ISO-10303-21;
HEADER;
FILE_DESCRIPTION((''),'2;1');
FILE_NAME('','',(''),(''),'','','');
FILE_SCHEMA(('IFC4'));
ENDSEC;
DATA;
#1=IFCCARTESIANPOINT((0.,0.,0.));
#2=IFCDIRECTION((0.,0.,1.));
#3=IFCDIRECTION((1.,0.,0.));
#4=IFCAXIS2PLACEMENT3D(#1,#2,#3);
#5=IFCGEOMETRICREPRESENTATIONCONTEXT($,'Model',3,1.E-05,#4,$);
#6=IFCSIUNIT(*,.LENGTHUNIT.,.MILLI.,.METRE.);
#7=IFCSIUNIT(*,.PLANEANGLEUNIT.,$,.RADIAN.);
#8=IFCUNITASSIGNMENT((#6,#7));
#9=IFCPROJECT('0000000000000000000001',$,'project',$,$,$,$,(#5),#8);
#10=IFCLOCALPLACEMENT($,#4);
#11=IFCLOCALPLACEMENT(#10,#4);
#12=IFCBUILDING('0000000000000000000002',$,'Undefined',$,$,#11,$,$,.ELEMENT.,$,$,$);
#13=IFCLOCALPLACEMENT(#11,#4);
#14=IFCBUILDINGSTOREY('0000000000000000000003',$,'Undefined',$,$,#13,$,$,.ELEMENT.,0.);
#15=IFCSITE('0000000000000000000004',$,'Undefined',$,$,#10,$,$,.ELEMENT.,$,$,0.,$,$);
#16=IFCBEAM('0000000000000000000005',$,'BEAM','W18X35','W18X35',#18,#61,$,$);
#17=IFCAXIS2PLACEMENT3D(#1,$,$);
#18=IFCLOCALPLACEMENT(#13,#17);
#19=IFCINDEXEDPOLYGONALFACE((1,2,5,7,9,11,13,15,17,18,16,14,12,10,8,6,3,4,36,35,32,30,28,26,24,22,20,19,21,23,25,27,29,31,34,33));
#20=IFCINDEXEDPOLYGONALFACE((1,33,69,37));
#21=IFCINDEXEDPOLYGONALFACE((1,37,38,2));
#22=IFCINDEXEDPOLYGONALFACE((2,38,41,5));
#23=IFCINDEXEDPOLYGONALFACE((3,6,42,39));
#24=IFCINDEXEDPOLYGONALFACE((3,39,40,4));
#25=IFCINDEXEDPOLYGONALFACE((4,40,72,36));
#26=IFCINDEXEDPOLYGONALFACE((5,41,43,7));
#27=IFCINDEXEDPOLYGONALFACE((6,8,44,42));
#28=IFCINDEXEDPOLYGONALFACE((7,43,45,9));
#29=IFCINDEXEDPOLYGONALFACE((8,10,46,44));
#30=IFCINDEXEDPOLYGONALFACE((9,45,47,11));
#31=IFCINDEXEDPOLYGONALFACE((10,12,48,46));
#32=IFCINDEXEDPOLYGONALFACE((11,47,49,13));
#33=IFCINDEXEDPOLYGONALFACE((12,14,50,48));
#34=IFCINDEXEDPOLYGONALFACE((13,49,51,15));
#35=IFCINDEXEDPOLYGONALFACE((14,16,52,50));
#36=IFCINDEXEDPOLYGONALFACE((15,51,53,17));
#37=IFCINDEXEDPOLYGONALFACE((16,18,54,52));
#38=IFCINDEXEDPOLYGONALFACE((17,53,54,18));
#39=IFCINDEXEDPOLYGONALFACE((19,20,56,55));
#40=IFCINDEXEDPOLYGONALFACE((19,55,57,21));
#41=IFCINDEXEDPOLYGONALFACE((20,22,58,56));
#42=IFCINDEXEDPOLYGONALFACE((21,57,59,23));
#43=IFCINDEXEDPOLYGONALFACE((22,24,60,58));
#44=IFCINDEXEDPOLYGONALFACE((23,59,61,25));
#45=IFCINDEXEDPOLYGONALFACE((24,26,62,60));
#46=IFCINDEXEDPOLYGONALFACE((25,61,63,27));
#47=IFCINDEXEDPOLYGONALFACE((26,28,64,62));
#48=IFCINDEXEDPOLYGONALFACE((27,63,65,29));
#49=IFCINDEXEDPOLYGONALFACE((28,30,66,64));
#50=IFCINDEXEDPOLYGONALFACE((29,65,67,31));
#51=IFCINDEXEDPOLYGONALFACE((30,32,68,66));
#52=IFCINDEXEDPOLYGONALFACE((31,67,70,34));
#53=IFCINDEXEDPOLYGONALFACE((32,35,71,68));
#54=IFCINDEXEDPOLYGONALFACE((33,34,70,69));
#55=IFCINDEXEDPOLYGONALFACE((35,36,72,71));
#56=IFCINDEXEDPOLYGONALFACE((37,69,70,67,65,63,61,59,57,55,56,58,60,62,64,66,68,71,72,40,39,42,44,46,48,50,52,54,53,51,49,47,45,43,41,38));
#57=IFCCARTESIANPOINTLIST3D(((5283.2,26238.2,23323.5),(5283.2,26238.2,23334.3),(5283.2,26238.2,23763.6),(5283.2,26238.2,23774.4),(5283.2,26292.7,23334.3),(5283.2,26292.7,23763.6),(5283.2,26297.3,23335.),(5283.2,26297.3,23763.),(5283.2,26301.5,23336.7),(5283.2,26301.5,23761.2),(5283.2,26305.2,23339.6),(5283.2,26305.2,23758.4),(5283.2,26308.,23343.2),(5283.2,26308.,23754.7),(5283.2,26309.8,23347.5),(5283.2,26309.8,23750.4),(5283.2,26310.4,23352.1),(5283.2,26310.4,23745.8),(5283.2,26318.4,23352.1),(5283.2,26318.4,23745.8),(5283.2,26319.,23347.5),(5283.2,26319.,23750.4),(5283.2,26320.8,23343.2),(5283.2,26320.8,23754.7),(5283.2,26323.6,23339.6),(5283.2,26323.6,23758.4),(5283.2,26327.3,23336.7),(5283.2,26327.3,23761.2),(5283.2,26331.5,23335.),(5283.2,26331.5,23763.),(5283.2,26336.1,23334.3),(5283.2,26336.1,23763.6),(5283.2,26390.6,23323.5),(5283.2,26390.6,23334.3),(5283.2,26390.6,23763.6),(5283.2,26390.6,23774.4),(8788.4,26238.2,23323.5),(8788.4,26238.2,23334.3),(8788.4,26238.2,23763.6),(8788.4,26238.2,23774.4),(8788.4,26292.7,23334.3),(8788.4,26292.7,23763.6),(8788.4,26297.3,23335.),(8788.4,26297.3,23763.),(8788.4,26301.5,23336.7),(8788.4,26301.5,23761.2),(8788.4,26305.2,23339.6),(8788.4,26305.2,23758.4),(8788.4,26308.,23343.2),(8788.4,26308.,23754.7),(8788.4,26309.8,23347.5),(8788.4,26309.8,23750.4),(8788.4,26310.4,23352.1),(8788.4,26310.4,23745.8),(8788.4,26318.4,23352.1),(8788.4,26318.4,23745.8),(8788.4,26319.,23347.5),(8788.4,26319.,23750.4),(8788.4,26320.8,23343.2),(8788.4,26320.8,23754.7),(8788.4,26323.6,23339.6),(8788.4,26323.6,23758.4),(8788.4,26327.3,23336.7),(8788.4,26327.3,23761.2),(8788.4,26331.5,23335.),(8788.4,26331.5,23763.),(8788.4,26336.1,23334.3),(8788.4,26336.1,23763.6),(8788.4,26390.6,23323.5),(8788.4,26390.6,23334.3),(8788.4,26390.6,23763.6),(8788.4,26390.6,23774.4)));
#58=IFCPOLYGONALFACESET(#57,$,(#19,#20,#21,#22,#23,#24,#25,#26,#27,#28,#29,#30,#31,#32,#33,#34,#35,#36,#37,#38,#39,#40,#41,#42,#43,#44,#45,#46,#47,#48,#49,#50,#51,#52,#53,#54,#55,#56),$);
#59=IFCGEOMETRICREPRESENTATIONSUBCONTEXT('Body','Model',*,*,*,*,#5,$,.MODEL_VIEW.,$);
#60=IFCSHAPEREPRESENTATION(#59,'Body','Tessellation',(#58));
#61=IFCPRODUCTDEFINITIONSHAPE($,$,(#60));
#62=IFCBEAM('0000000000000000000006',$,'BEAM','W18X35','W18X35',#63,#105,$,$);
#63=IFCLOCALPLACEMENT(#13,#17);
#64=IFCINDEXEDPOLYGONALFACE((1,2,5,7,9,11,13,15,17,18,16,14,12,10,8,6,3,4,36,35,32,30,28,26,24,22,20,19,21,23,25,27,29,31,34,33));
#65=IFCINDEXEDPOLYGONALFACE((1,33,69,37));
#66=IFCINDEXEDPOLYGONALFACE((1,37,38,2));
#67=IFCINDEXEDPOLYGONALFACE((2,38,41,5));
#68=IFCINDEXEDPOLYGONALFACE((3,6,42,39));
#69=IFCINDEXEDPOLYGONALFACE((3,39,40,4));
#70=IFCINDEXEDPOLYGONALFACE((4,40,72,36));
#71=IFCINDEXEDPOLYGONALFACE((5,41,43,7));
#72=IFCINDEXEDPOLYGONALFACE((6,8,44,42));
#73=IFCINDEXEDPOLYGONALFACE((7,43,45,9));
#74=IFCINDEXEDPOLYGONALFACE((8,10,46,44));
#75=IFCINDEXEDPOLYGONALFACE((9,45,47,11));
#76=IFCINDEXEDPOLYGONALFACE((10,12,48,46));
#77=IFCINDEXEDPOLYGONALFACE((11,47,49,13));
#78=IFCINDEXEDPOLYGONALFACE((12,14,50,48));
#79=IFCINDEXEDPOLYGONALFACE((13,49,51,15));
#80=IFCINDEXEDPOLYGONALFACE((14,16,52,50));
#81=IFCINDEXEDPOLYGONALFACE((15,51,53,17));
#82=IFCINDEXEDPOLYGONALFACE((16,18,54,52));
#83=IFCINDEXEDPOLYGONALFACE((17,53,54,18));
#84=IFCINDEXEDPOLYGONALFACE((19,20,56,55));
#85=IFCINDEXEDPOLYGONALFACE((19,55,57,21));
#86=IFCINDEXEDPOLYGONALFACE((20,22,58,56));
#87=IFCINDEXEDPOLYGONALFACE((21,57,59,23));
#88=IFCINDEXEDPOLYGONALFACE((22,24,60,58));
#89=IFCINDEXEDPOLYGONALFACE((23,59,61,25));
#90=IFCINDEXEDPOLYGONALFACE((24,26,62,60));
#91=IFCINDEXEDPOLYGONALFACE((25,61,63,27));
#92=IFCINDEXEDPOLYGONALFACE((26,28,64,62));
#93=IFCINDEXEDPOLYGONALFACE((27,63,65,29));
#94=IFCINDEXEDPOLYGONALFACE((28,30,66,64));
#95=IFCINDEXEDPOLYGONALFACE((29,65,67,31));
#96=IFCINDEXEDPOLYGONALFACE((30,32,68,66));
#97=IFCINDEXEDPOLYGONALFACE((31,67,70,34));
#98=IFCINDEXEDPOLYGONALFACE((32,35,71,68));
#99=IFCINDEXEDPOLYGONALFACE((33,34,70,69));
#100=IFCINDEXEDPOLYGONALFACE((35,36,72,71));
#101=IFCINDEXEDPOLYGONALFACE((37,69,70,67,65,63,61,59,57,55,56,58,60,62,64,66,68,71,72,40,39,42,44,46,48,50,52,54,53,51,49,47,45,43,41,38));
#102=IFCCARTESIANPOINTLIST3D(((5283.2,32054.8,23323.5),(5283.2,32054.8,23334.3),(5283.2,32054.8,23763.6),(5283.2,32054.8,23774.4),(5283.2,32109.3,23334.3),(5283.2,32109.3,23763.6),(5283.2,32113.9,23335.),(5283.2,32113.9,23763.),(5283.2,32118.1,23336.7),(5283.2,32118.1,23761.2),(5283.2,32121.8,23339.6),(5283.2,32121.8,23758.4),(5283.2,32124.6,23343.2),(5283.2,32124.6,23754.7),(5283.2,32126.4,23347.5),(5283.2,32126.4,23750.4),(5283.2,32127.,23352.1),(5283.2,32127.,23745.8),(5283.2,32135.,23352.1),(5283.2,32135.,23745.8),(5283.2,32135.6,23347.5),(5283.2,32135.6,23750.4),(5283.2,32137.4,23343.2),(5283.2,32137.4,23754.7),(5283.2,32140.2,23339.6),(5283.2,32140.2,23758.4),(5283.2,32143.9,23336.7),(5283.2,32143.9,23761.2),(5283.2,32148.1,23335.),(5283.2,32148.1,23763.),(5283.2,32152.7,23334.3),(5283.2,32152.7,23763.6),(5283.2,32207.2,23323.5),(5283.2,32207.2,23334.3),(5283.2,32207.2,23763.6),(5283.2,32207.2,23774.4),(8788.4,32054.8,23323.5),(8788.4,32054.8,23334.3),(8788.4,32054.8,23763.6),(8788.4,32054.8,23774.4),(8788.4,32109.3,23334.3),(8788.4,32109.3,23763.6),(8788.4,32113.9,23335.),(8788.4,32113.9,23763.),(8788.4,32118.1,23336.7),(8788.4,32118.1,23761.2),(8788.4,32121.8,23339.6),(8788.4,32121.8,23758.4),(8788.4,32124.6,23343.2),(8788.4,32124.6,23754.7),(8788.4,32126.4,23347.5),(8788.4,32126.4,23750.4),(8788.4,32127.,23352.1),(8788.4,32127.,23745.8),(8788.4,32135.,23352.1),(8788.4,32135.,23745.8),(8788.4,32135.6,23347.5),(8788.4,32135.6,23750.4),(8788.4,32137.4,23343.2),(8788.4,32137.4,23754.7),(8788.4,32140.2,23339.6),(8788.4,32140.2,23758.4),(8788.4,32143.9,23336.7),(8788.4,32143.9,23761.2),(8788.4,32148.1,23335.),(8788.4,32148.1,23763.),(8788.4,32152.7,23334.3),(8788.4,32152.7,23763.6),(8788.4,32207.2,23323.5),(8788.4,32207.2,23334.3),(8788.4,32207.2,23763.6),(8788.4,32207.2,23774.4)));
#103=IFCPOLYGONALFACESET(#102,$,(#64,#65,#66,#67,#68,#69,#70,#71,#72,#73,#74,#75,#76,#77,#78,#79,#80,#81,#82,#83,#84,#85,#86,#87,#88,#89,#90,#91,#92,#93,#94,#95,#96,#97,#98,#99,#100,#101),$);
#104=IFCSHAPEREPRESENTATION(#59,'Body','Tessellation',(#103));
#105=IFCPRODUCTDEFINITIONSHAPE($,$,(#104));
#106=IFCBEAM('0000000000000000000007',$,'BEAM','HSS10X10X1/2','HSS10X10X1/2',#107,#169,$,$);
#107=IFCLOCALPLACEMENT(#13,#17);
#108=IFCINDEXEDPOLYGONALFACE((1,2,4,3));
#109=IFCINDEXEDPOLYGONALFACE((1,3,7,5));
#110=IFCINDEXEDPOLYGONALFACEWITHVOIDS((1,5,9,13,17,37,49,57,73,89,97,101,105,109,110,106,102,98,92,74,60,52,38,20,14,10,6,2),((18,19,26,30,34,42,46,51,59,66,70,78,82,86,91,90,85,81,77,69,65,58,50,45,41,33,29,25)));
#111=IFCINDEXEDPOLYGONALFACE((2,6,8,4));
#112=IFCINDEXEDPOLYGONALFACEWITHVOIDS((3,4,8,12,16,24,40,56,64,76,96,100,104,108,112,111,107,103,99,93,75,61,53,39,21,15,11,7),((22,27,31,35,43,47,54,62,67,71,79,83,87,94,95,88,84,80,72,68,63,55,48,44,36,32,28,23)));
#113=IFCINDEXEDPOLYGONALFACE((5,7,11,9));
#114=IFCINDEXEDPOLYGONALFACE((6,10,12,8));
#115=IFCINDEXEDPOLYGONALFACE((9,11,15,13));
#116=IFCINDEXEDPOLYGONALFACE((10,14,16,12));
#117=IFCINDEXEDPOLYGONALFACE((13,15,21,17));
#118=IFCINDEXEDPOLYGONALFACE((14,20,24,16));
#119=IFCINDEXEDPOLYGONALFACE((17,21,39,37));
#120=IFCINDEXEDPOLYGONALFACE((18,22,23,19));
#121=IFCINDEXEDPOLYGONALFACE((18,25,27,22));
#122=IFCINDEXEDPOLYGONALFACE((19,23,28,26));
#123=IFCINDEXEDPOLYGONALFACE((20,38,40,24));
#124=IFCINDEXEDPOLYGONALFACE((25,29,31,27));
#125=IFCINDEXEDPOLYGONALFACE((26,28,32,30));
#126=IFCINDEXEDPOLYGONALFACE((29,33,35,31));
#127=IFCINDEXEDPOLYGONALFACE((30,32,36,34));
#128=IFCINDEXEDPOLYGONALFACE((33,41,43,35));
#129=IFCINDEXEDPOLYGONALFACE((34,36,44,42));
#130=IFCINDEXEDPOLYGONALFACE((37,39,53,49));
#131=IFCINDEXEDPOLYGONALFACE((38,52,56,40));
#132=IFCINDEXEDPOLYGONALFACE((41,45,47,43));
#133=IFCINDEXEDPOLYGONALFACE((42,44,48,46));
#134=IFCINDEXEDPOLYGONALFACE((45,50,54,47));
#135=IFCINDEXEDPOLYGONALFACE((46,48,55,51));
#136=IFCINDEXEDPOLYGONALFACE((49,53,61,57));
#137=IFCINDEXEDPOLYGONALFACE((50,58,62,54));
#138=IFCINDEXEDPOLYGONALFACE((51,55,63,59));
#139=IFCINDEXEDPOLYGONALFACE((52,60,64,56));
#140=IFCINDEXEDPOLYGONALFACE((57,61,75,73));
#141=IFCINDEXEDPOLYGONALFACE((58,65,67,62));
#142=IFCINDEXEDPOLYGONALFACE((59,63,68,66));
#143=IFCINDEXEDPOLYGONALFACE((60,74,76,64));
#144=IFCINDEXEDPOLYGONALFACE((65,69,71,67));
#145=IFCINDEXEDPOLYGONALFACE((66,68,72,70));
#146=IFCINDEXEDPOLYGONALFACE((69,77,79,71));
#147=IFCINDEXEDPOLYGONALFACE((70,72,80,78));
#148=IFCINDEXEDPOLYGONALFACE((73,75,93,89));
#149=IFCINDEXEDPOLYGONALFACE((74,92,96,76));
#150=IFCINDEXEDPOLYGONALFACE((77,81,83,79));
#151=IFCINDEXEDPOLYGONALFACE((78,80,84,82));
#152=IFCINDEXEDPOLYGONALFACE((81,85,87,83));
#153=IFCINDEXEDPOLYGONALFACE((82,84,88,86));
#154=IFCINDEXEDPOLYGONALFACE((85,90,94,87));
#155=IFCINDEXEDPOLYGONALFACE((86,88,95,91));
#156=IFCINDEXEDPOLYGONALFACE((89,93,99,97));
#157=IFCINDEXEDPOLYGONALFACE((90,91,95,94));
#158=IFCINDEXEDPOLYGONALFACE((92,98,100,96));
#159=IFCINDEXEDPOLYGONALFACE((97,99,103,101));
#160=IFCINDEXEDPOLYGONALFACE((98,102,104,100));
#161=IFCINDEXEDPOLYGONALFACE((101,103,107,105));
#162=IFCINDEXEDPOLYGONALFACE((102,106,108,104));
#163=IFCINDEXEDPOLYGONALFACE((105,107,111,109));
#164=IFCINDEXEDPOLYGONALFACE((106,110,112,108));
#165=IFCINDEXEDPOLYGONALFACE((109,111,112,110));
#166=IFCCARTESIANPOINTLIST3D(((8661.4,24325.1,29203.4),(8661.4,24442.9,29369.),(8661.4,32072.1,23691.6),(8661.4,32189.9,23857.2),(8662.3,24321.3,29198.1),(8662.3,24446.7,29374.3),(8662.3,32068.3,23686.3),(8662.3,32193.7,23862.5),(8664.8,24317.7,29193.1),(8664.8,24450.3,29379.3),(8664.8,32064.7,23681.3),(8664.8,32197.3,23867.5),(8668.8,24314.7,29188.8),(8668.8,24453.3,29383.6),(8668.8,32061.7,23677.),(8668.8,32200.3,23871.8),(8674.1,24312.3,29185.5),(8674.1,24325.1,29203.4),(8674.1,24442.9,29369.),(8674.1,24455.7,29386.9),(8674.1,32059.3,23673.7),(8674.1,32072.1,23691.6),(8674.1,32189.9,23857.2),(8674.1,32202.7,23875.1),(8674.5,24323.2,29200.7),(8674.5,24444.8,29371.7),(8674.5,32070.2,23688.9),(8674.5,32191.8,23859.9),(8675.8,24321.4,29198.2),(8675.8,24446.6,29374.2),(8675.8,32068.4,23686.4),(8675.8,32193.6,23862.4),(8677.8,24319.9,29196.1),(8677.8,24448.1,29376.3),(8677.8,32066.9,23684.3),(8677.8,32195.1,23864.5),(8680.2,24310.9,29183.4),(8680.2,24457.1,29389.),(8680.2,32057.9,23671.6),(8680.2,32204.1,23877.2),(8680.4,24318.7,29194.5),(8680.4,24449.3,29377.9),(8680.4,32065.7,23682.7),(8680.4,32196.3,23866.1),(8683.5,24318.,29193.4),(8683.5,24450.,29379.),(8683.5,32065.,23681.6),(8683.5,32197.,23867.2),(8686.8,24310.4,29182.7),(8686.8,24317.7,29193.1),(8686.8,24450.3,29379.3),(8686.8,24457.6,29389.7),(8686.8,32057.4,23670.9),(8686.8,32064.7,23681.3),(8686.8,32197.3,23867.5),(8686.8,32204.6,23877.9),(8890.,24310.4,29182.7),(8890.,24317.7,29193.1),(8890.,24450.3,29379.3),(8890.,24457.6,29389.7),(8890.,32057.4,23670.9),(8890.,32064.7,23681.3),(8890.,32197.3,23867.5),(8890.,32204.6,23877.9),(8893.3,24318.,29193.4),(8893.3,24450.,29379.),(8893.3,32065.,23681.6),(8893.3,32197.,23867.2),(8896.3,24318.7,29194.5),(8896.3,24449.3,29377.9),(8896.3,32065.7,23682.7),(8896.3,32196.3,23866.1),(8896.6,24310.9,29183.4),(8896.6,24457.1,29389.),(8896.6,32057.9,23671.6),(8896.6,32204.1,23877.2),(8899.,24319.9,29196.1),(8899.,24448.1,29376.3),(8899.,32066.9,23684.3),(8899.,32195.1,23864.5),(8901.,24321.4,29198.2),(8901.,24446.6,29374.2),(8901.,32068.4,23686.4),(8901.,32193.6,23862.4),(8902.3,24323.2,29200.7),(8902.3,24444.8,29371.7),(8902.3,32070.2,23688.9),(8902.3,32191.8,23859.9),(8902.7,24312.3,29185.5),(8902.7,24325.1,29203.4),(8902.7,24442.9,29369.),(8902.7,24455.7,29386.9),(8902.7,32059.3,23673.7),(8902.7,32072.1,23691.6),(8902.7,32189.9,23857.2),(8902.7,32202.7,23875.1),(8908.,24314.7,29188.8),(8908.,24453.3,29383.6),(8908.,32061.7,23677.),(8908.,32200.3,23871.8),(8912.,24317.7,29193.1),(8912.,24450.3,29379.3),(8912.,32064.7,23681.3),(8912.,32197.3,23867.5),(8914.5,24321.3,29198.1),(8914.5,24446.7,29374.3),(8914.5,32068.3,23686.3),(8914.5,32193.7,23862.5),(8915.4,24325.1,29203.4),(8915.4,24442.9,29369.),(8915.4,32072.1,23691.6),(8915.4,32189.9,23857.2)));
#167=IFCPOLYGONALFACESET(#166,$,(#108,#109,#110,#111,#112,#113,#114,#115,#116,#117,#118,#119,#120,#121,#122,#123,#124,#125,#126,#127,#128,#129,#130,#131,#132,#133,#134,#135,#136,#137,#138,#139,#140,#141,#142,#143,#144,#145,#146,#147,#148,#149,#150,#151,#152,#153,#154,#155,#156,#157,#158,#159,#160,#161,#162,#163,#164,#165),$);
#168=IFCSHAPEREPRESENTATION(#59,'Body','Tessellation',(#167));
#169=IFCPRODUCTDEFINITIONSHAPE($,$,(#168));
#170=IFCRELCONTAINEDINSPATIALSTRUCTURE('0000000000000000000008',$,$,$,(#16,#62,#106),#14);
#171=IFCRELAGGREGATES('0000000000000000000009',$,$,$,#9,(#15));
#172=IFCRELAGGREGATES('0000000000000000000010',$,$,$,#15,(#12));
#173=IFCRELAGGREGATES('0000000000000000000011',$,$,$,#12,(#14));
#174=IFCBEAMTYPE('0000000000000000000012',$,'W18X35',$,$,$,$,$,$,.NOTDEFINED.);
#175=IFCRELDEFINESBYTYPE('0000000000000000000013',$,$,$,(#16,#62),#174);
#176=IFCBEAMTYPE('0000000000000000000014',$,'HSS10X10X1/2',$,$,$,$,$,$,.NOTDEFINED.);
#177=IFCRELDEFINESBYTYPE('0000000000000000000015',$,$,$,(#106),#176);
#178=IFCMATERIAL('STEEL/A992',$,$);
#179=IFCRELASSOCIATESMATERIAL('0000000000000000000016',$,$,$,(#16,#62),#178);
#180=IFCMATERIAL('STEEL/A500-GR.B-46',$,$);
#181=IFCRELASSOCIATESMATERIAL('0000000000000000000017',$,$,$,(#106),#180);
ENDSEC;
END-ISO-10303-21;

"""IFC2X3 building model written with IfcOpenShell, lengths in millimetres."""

from ifc_helpers import new_model, si_unit, frame, origin_with_axes, origin_2d_with_axis, place, context, subcontext, project, spatial, hollow_rectangle, i_section, extrude, material, type_object, element, save


model = new_model("IFC2X3")

# Units and contexts
model_context = context("Model", 3, precision=1e-05, world=origin_with_axes())
body_context = subcontext(model_context, "Body", "Model", "MODEL_VIEW")
ifc_project = project(units=[si_unit("LENGTHUNIT", "METRE", prefix="MILLI"), si_unit("PLANEANGLEUNIT", "RADIAN")], contexts=[model_context])

# Site, building, storey
site_placement = place(None, origin_with_axes())
site = spatial("IfcSite", under=ifc_project, at=site_placement, Name="Undefined", CompositionType="ELEMENT", RefElevation=0.0)
building_placement = place(site_placement, origin_with_axes())
building = spatial("IfcBuilding", under=site, at=building_placement, Name="Undefined", CompositionType="ELEMENT")
storey_placement = place(building_placement, origin_with_axes())
storey = spatial("IfcBuildingStorey", under=building, at=storey_placement, Name="Undefined", CompositionType="ELEMENT", Elevation=0.0)

# Shared definitions
ifc_material_1 = material(Name="STEEL/A992")

# Beams
beam_type_1 = type_object("IfcBeamType", Name="W18X35", PredefinedType="NOTDEFINED")
beam_1_placement = place(storey_placement, frame((5283.2, 26314.4, 23549.0), z_axis=(0.0, 0.0, 1.0), x_axis=(1.0, 0.0, 0.0)))
element("IfcBeam", 1, at=beam_1_placement, inside=storey, type_object=beam_type_1, material=ifc_material_1, Name="BEAM", Description="W18X35", ObjectType="W18X35", context=body_context, shape_type="SweptSolid", body=[
    extrude(i_section(OverallWidth=152.4, OverallDepth=450.9, WebThickness=7.9, FlangeThickness=10.8, FilletRadius=17.8, at=origin_2d_with_axis()), frame((3505.2, 0.0, 0.0), z_axis=(-1.0, 0.0, 0.0), x_axis=(0.0, -1.0, 0.0)), (0.0, 0.0, 1.0), 3505.2),
])
beam_2_placement = place(storey_placement, frame((5283.2, 32131.0, 23549.0), z_axis=(0.0, 0.0, 1.0), x_axis=(1.0, 0.0, 0.0)))
element("IfcBeam", 2, at=beam_2_placement, inside=storey, type_object=beam_type_1, material=ifc_material_1, Name="BEAM", Description="W18X35", ObjectType="W18X35", context=body_context, shape_type="SweptSolid", body=[
    extrude(i_section(OverallWidth=152.4, OverallDepth=450.9, WebThickness=7.9, FlangeThickness=10.8, FilletRadius=17.8, at=origin_2d_with_axis()), frame((3505.2, 0.0, 0.0), z_axis=(-1.0, 0.0, 0.0), x_axis=(0.0, -1.0, 0.0)), (0.0, 0.0, 1.0), 3505.2),
])
ifc_material_2 = material(Name="STEEL/A500-GR.B-46")
beam_type_2 = type_object("IfcBeamType", Name="HSS10X10X1/2", PredefinedType="NOTDEFINED")
beam_3_placement = place(storey_placement, frame((8788.4, 32131.0, 23774.4), z_axis=(0.0, 0.579721, 0.814815), x_axis=(0.0, -0.814815, 0.579721)))
element("IfcBeam", 3, at=beam_3_placement, inside=storey, type_object=beam_type_2, material=ifc_material_2, Name="BEAM", Description="HSS10X10X1/2", ObjectType="HSS10X10X1/2", context=body_context, shape_type="SweptSolid", body=[
    extrude(hollow_rectangle(XDim=254.0, YDim=254.0, WallThickness=12.7, InnerFilletRadius=12.7, OuterFilletRadius=25.4, at=origin_2d_with_axis()), frame((9507.7, 0.0, 0.0), z_axis=(-1.0, 0.0, 0.0), x_axis=(0.0, -1.0, 0.0)), (0.0, 0.0, 1.0), 9507.7),
])

save(model, "model.ifc")
